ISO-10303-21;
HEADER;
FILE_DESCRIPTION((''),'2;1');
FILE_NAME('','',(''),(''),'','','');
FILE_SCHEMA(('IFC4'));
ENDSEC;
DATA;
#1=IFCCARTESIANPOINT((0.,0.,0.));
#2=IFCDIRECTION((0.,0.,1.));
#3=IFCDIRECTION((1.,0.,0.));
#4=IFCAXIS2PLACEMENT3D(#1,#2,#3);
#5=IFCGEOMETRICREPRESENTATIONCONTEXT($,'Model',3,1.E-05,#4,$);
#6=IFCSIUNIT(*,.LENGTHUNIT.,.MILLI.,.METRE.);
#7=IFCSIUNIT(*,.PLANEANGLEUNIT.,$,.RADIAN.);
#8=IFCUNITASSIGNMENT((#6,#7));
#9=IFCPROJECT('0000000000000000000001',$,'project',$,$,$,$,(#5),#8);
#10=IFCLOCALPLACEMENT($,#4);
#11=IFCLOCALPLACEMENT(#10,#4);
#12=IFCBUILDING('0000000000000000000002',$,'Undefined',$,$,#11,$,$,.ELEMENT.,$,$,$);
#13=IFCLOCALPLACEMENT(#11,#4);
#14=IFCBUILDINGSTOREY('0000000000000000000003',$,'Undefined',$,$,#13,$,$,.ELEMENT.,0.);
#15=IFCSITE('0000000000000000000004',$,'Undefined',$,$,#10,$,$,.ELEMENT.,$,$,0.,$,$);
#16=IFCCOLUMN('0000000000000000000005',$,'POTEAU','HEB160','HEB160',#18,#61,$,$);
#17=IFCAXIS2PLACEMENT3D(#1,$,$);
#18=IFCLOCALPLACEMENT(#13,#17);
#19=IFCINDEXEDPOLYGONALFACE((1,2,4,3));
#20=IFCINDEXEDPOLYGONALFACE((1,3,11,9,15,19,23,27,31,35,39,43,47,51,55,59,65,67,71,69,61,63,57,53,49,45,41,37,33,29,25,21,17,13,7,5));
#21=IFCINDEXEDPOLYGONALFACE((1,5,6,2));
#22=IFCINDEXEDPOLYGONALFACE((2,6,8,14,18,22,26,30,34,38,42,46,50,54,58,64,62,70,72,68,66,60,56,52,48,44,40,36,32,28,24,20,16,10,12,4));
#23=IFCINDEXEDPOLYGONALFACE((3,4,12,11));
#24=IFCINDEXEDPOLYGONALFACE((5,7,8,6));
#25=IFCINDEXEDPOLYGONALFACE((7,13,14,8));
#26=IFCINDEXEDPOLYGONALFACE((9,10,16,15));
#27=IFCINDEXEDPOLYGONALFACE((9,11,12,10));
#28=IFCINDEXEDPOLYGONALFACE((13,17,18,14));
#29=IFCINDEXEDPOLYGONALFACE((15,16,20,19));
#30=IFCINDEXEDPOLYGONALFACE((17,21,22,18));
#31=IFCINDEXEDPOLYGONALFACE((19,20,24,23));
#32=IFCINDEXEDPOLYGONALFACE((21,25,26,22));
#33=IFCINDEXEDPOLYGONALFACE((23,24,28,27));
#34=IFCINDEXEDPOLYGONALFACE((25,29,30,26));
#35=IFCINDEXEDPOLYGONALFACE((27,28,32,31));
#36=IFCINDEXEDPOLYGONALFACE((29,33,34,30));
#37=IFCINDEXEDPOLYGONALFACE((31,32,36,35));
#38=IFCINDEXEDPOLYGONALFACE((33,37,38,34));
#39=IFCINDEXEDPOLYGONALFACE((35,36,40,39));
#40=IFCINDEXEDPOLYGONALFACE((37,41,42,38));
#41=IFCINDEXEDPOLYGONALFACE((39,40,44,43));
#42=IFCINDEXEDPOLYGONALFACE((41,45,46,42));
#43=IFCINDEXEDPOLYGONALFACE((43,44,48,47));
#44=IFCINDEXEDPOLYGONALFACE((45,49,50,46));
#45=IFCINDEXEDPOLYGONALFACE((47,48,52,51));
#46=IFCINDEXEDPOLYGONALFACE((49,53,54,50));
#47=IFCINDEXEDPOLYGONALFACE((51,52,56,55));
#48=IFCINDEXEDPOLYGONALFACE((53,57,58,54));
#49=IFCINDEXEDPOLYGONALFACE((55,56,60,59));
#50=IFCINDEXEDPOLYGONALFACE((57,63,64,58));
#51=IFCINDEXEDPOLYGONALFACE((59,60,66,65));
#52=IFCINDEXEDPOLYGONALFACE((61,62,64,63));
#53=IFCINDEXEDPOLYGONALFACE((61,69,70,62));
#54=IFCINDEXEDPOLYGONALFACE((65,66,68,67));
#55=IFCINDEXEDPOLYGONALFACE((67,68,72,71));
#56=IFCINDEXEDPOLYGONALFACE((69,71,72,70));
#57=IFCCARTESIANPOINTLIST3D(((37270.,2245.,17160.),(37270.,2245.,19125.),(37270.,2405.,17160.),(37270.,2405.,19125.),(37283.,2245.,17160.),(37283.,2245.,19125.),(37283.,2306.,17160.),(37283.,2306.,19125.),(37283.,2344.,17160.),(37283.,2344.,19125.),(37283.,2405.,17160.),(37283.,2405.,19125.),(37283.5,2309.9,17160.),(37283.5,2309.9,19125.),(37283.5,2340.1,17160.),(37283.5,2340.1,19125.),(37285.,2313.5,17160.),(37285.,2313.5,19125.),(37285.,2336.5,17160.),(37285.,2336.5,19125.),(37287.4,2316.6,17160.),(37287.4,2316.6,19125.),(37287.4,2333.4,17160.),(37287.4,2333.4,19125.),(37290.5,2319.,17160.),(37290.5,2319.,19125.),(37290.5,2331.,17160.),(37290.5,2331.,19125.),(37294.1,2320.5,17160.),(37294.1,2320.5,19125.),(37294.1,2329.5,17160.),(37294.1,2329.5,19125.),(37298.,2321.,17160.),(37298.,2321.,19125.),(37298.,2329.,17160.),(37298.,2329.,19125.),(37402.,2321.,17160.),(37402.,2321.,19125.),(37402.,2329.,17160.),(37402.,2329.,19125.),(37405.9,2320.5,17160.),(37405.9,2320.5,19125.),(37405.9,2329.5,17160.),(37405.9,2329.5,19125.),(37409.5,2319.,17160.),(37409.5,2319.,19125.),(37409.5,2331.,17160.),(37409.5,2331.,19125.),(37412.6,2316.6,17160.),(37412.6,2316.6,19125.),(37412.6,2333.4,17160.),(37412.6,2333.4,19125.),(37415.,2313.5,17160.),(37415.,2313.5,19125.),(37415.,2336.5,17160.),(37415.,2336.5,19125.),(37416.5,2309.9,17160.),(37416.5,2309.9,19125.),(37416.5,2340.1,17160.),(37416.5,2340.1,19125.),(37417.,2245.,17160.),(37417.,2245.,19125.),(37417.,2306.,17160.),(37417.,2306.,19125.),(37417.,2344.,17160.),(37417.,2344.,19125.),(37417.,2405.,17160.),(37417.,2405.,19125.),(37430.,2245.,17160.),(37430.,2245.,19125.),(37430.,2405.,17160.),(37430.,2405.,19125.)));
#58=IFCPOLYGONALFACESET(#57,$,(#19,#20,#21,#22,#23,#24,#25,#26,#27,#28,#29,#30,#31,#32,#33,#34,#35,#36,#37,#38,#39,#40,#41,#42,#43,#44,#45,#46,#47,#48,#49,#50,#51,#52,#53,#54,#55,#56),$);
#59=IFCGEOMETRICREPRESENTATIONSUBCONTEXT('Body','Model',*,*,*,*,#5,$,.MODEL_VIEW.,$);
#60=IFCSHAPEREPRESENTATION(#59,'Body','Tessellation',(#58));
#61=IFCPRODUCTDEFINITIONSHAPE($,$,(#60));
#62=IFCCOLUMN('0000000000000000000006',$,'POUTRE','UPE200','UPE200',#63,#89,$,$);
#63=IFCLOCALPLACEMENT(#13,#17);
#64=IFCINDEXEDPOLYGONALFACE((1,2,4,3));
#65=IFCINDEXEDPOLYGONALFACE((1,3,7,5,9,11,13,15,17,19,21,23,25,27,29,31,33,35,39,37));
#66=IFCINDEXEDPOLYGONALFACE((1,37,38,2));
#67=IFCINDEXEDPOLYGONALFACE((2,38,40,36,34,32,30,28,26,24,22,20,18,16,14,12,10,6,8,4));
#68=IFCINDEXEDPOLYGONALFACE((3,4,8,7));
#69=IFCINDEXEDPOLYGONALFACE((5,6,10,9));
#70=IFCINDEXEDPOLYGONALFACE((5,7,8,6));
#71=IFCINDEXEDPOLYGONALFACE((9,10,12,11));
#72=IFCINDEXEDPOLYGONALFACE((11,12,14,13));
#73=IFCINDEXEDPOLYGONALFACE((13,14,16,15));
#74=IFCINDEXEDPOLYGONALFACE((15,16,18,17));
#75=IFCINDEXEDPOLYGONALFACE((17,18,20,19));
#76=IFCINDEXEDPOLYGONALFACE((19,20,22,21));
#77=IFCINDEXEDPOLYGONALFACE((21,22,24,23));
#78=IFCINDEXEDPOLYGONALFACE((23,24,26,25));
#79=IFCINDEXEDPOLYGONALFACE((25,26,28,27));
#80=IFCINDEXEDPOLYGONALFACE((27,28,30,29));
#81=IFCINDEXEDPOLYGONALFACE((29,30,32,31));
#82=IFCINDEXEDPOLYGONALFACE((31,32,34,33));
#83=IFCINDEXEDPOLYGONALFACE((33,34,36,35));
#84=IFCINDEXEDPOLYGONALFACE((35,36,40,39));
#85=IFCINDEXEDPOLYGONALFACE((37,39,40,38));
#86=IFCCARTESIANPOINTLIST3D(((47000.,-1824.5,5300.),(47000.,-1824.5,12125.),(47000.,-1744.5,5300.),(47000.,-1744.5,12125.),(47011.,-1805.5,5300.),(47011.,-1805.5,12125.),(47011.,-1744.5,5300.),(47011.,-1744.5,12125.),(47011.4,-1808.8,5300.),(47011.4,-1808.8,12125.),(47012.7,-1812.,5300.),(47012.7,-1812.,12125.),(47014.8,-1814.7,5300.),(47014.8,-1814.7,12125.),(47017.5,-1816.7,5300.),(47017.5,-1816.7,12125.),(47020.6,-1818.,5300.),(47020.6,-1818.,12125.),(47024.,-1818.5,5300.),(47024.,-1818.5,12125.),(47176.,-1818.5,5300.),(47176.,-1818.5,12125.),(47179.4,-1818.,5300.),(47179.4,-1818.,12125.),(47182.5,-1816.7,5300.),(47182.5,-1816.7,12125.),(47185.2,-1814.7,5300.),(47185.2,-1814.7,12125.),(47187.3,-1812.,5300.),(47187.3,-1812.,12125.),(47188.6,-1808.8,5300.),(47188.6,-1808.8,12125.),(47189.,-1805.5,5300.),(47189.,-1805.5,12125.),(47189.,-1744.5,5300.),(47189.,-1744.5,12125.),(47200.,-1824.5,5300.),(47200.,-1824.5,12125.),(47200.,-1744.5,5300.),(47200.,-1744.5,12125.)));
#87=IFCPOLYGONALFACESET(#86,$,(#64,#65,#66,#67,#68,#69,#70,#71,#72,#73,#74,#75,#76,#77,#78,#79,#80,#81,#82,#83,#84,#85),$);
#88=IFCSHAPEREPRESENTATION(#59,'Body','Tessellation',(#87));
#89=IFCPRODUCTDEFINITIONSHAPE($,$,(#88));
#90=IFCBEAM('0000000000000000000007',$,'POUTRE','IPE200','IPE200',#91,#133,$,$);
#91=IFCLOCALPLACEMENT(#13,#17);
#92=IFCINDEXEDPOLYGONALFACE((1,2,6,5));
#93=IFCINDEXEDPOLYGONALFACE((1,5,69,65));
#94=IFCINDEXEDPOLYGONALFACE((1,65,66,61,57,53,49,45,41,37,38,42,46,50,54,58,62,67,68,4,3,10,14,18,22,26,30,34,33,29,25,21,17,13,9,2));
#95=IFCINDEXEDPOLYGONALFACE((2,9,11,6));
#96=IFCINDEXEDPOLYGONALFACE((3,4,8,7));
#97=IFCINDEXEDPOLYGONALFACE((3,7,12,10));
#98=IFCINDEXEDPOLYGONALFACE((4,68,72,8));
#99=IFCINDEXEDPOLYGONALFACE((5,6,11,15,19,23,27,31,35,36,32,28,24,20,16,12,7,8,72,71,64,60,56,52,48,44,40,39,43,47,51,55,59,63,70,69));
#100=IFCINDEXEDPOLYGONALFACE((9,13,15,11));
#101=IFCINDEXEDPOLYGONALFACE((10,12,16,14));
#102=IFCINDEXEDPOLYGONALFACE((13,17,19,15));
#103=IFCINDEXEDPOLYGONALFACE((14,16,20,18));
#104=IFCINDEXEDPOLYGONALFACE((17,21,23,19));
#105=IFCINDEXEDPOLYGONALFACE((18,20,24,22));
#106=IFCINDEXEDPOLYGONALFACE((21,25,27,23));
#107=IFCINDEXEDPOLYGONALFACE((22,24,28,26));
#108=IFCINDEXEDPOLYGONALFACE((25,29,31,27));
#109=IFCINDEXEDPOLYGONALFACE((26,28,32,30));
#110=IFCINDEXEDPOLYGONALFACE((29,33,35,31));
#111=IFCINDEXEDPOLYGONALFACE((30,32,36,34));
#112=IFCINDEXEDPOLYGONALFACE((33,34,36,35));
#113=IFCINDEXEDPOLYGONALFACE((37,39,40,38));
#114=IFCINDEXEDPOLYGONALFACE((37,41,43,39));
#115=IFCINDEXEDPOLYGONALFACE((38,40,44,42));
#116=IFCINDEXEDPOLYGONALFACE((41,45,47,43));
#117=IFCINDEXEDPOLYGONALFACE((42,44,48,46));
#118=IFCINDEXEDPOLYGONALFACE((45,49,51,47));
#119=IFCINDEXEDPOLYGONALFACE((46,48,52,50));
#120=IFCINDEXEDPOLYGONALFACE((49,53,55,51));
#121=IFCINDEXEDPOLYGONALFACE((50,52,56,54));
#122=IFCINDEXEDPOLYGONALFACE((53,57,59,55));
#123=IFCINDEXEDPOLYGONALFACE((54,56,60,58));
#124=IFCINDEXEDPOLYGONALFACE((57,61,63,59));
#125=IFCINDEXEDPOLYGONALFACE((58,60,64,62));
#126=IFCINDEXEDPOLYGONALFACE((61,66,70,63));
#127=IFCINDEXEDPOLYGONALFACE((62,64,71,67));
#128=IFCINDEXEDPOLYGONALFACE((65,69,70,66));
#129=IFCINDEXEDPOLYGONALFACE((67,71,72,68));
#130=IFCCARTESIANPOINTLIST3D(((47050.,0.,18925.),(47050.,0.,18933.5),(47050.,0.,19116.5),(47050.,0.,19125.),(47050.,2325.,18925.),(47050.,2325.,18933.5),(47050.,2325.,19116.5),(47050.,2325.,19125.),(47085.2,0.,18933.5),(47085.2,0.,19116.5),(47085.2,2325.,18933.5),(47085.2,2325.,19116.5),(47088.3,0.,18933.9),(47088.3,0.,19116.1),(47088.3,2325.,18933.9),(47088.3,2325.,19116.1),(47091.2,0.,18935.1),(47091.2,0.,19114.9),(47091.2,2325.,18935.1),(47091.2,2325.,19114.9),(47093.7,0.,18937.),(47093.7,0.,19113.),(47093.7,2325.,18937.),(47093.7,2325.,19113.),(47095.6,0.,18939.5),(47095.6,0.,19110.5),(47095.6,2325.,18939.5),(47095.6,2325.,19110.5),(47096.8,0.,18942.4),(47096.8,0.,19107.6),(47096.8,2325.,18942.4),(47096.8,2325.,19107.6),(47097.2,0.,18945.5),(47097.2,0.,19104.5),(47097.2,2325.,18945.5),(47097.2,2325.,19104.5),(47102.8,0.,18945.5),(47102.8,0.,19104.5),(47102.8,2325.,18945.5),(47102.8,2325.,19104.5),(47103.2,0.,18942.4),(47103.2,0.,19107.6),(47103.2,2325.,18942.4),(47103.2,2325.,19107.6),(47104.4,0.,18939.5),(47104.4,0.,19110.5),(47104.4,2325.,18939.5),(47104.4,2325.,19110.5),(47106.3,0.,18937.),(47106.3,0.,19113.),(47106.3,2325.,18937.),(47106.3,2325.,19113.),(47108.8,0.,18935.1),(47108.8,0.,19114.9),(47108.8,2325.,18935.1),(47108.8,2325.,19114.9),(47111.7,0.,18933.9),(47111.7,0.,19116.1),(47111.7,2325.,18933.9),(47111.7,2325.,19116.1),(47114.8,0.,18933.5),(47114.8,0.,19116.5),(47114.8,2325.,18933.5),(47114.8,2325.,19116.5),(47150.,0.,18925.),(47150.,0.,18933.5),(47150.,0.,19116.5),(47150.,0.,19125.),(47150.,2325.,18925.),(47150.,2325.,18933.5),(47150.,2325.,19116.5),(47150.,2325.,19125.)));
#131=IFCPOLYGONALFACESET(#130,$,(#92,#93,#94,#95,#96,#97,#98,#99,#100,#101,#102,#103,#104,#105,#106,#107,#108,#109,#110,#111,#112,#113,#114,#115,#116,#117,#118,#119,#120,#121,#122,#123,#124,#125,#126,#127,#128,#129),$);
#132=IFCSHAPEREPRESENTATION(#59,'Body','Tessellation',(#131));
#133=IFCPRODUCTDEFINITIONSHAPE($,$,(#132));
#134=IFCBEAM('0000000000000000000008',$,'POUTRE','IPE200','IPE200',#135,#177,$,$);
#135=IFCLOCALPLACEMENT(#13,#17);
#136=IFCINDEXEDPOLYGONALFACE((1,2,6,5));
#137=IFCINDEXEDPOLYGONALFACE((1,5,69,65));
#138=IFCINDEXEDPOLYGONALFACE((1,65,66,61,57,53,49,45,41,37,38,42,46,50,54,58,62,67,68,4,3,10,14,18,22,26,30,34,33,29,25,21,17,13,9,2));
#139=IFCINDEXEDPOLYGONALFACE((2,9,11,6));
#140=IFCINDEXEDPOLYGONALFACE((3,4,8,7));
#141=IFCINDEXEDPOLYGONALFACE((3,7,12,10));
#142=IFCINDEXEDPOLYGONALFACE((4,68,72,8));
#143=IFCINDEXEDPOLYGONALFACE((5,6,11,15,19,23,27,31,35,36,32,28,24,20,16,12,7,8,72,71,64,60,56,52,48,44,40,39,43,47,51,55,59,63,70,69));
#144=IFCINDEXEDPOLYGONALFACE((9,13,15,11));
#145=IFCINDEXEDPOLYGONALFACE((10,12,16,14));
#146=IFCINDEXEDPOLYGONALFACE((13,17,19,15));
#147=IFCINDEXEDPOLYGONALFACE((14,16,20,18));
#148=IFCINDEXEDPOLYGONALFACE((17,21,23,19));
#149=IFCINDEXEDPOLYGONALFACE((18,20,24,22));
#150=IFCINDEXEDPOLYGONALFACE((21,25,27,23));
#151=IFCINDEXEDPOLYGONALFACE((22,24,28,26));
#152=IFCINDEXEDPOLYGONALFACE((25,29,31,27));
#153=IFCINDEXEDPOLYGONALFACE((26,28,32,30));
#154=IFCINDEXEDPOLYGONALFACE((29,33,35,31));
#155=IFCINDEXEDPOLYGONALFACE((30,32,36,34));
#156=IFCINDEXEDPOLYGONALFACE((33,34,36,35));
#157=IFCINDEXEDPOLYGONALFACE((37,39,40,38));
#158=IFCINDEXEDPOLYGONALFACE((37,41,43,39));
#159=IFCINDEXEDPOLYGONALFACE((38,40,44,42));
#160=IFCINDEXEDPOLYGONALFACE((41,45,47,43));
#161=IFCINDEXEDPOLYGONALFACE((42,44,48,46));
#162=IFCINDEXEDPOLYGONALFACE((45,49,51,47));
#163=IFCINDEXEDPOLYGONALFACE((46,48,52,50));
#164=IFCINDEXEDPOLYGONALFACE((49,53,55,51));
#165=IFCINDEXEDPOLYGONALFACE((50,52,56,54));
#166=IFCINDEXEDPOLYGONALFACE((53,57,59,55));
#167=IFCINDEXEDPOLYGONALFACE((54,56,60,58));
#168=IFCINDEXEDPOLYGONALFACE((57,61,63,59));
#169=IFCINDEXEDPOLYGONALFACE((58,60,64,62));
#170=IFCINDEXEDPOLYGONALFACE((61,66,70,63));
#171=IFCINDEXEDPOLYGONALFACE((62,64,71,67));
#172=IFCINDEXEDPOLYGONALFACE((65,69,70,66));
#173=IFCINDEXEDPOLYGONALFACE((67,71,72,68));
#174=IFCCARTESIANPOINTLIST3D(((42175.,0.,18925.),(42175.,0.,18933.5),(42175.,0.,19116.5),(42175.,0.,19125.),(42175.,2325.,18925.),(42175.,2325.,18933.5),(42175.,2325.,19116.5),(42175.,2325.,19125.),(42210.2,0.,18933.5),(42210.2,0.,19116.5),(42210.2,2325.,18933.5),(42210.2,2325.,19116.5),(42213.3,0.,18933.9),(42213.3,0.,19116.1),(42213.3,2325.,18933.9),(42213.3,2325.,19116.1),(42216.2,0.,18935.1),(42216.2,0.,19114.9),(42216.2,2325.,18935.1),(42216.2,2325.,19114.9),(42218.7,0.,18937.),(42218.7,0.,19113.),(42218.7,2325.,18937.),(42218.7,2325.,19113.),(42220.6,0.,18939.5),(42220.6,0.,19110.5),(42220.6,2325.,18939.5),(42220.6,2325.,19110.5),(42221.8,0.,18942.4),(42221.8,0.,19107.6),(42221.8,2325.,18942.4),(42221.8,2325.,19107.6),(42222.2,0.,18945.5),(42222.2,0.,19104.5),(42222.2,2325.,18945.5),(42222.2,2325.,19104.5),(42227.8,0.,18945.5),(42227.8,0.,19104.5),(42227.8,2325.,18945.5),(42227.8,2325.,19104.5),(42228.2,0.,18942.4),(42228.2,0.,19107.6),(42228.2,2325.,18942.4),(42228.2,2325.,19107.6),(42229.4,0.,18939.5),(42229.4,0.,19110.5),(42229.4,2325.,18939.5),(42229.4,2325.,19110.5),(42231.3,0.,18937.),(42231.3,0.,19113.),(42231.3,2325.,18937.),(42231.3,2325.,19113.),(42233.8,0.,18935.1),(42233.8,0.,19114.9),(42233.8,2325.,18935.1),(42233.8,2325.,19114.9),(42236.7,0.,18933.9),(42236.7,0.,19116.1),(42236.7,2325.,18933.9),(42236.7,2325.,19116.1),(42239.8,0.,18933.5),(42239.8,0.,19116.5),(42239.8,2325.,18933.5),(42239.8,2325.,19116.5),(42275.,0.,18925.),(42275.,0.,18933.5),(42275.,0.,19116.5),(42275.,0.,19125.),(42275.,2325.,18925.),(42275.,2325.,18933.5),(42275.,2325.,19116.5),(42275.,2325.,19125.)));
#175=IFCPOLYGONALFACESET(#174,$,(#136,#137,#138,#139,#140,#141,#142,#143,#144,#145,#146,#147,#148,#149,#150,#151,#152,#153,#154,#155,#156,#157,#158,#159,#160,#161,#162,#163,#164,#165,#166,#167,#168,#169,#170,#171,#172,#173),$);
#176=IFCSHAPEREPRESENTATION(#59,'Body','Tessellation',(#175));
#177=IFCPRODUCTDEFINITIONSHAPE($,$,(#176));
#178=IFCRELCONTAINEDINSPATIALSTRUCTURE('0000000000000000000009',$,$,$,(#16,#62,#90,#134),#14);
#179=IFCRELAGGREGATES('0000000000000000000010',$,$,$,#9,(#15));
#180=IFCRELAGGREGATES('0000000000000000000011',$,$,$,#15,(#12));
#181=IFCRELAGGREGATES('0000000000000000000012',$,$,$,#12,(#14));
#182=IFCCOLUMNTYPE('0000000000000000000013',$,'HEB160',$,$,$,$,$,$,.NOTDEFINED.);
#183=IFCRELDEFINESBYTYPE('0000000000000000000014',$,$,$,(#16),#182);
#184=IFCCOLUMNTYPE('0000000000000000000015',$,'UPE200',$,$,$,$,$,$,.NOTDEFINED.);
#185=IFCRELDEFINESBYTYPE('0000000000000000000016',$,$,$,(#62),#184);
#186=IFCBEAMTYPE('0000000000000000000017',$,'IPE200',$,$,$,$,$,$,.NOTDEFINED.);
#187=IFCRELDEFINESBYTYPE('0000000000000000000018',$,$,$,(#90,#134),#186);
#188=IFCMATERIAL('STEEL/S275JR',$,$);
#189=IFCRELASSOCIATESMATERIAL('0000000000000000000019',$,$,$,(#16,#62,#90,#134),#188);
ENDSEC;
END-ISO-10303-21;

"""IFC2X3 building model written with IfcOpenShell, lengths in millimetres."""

from ifc_helpers import new_model, si_unit, frame, origin_with_axes, origin_2d_with_axis, place, context, subcontext, project, spatial, i_section, u_section, extrude, material, type_object, element, save


model = new_model("IFC2X3")

# Units and contexts
model_context = context("Model", 3, precision=1e-05, world=origin_with_axes())
body_context = subcontext(model_context, "Body", "Model", "MODEL_VIEW")
ifc_project = project(units=[si_unit("LENGTHUNIT", "METRE", prefix="MILLI"), si_unit("PLANEANGLEUNIT", "RADIAN")], contexts=[model_context])

# Site, building, storey
site_placement = place(None, origin_with_axes())
site = spatial("IfcSite", under=ifc_project, at=site_placement, Name="Undefined", CompositionType="ELEMENT", RefElevation=0.0)
building_placement = place(site_placement, origin_with_axes())
building = spatial("IfcBuilding", under=site, at=building_placement, Name="Undefined", CompositionType="ELEMENT")
storey_placement = place(building_placement, origin_with_axes())
storey = spatial("IfcBuildingStorey", under=building, at=storey_placement, Name="Undefined", CompositionType="ELEMENT", Elevation=0.0)

# Columns
ifc_material_1 = material(Name="STEEL/S275JR")
column_type_1 = type_object("IfcColumnType", Name="HEB160", PredefinedType="NOTDEFINED")
for number, where, z_axis, x_axis, name in (
    (1, (37350.0, 2325.0, 17160.0), (0.0, 0.0, 1.0), (1.0, 0.0, 0.0), "POTEAU"),
):
    element("IfcColumn", number, at=place(storey_placement, frame(where, z_axis=z_axis, x_axis=x_axis)), inside=storey, type_object=column_type_1, material=ifc_material_1, Name=name, Description="HEB160", ObjectType="HEB160", context=body_context, shape_type="SweptSolid", body=[
        extrude(i_section(OverallWidth=160.0, OverallDepth=160.0, WebThickness=8.0, FlangeThickness=13.0, FilletRadius=15.0, at=origin_2d_with_axis()), frame((0.0, 0.0, 1965.0), z_axis=(0.0, 0.0, -1.0), x_axis=(0.0, -1.0, 0.0)), (0.0, 0.0, 1.0), 1965.0),
    ])
column_type_2 = type_object("IfcColumnType", Name="UPE200", PredefinedType="NOTDEFINED")
column_1_placement = place(storey_placement, frame((47100.0, -1784.5, 5300.0), z_axis=(0.0, 0.0, 1.0), x_axis=(1.0, 0.0, 0.0)))
element("IfcColumn", 2, at=column_1_placement, inside=storey, type_object=column_type_2, material=ifc_material_1, Name="POUTRE", Description="UPE200", ObjectType="UPE200", context=body_context, shape_type="SweptSolid", body=[
    extrude(u_section(Depth=200.0, FlangeWidth=80.0, WebThickness=6.0, FlangeThickness=11.0, FilletRadius=13.0, at=origin_2d_with_axis()), frame((0.0, 0.0, 6825.0), z_axis=(0.0, 0.0, -1.0), x_axis=(0.0, 1.0, 0.0)), (0.0, 0.0, 1.0), 6825.0),
])

# Beams
beam_type_1 = type_object("IfcBeamType", Name="IPE200", PredefinedType="NOTDEFINED")
for number, where, z_axis, x_axis, name in (
    (3, (47100.0, 0.0, 19025.0), (0.0, 0.000013, 1.0), (0.0, 1.0, -0.000013), "POUTRE"),
    (4, (42225.0, 0.0, 19025.0), (0.0, 0.000013, 1.0), (0.0, 1.0, -0.000013), "POUTRE"),
):
    element("IfcBeam", number, at=place(storey_placement, frame(where, z_axis=z_axis, x_axis=x_axis)), inside=storey, type_object=beam_type_1, material=ifc_material_1, Name=name, Description="IPE200", ObjectType="IPE200", context=body_context, shape_type="SweptSolid", body=[
        extrude(i_section(OverallWidth=100.0, OverallDepth=200.0, WebThickness=5.6, FlangeThickness=8.5, FilletRadius=12.0, at=origin_2d_with_axis()), frame((2325.0, 0.0, 0.0), z_axis=(-1.0, 0.0, 0.0), x_axis=(0.0, -1.0, 0.0)), (0.0, 0.0, 1.0), 2325.0),
    ])

save(model, "model.ifc")
